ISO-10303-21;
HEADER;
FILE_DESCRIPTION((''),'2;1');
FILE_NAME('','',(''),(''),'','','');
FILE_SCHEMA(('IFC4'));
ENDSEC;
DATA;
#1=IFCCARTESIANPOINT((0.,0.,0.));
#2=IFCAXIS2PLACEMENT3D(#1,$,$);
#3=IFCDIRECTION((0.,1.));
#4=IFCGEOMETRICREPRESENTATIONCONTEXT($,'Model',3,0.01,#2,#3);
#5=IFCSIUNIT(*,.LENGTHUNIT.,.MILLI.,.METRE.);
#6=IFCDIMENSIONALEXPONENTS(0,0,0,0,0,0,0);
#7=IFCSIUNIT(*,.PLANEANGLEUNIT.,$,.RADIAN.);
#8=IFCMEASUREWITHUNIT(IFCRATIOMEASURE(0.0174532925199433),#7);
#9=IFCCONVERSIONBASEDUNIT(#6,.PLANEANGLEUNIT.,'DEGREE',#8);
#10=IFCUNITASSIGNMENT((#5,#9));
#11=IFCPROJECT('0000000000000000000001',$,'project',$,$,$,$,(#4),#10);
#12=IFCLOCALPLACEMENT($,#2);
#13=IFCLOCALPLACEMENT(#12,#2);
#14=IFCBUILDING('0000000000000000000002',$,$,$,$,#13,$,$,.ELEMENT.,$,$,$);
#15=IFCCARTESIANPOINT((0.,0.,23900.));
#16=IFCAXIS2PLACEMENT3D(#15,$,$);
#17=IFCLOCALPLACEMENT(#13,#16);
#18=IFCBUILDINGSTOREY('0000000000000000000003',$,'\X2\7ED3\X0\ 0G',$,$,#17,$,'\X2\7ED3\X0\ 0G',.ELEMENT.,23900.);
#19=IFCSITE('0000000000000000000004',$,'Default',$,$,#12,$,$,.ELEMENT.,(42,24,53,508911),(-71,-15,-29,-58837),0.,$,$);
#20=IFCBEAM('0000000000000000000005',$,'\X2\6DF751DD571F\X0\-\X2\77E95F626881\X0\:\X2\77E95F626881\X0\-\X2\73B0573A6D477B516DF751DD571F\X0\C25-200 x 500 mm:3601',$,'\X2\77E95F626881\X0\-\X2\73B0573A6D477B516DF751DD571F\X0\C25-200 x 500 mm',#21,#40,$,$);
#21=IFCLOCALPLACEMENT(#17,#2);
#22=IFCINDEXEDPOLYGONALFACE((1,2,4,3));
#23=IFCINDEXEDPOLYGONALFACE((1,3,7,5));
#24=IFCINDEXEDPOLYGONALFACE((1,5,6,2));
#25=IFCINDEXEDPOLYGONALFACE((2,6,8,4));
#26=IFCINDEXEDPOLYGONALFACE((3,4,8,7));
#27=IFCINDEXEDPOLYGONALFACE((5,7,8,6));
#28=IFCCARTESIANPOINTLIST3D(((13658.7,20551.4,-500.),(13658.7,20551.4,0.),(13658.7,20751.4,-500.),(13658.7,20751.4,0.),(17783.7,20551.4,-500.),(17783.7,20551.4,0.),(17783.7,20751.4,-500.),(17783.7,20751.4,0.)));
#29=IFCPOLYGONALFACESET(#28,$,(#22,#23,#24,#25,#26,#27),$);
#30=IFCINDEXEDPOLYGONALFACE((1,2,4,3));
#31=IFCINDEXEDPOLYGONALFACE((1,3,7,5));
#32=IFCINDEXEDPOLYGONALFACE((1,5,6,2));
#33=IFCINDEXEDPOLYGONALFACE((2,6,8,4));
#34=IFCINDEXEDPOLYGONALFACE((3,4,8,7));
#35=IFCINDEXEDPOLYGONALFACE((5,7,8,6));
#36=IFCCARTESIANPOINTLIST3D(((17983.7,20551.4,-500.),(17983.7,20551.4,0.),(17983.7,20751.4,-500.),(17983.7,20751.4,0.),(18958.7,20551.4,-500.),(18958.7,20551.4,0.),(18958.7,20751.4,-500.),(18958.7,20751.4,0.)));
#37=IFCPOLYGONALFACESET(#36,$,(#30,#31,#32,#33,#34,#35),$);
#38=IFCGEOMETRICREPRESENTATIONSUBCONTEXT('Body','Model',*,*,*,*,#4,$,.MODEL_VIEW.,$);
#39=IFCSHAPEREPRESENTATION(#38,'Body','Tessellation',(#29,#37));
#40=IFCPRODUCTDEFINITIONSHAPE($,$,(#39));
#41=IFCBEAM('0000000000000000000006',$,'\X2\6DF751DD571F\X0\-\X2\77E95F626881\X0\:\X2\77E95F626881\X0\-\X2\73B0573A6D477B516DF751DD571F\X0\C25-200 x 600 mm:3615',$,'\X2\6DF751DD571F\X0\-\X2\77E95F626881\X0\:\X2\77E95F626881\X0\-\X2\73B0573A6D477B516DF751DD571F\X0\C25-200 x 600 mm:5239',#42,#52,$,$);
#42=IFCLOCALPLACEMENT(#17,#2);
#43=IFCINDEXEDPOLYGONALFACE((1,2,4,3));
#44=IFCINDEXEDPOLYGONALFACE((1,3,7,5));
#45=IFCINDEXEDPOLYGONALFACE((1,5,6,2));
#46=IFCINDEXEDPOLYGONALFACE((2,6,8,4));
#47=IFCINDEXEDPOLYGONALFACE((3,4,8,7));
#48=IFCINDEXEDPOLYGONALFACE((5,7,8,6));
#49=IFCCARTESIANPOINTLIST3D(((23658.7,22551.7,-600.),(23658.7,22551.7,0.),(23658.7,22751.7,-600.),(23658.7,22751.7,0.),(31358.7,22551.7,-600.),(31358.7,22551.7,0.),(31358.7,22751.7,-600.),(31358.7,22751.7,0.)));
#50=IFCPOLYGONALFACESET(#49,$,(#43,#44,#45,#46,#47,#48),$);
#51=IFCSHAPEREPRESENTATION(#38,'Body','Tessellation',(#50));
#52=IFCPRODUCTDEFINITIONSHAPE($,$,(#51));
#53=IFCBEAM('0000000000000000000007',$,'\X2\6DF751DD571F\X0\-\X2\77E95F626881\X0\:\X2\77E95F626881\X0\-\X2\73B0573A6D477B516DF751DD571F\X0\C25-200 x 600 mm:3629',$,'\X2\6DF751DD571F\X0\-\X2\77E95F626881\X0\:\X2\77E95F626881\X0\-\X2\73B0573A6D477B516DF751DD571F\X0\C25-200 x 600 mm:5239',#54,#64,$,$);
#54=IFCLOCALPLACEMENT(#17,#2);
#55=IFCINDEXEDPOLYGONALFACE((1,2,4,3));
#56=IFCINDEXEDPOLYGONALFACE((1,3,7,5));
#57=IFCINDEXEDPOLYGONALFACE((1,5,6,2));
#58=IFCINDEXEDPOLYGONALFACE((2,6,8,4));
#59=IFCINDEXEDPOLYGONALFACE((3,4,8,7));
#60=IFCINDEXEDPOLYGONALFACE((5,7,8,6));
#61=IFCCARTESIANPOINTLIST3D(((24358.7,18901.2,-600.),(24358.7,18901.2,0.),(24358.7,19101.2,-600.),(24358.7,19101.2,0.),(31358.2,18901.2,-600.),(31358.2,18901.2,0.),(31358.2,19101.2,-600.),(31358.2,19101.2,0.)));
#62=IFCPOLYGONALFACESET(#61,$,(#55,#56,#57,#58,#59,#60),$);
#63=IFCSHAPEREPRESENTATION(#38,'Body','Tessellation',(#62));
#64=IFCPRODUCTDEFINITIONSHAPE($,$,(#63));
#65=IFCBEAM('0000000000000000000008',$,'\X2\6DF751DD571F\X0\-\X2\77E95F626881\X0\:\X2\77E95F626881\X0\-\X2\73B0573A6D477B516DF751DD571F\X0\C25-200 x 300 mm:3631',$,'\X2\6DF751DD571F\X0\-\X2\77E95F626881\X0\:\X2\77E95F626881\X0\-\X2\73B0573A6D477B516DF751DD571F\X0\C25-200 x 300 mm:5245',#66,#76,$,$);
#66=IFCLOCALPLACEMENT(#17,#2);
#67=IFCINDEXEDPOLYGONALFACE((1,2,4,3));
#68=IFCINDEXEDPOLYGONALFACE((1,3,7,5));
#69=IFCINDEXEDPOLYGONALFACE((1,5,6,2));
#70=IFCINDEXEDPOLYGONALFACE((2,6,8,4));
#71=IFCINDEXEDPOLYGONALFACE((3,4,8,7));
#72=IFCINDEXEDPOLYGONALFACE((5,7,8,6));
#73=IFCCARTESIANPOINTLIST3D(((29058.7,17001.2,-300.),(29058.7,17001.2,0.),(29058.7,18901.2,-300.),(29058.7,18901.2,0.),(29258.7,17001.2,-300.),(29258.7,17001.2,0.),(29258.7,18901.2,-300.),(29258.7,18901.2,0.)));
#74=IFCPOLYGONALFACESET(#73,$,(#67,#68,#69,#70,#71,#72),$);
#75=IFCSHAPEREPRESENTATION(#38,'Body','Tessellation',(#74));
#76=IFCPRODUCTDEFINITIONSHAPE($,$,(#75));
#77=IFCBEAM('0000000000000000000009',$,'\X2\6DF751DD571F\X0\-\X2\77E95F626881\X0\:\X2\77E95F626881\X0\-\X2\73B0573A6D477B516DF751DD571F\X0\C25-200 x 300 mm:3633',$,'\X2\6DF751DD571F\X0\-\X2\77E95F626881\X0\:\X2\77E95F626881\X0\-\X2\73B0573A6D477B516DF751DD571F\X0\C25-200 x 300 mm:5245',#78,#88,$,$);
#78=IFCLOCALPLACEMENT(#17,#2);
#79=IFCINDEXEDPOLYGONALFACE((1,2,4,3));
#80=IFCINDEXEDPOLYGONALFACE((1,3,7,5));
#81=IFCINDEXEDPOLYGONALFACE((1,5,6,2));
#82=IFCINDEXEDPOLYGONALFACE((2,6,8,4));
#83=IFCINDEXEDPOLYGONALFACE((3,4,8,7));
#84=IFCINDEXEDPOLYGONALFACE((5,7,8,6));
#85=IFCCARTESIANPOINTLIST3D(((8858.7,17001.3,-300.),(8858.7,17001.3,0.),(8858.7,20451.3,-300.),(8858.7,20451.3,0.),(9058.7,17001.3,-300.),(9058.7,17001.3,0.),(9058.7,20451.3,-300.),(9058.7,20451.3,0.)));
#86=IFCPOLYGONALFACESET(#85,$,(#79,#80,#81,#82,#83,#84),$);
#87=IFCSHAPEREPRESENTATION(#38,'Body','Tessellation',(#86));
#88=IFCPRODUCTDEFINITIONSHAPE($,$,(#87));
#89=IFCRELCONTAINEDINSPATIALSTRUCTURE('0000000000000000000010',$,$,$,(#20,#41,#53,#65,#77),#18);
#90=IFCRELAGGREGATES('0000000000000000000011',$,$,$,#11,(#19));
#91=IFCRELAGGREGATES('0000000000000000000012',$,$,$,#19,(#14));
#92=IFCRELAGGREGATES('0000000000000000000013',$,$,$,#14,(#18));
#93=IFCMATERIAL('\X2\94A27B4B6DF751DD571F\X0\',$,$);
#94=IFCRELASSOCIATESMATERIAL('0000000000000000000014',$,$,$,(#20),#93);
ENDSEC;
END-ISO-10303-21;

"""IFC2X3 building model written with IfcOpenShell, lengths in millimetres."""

from ifc_helpers import new_model, entity, si_unit, converted_unit, direction, frame, frame_2d, origin, origin_2d_with_axis, place, context, subcontext, project, spatial, rectangle, extrude, source, transform, mapped, material, element, save


model = new_model("IFC2X3")

# Units and contexts
model_context = context("Model", 3, precision=0.01, world=origin(), true_north=direction((0.0, 1.0)))
body_context = subcontext(model_context, "Body", "Model", "MODEL_VIEW")
ifc_project = project(units=[si_unit("LENGTHUNIT", "METRE", prefix="MILLI"), converted_unit("PLANEANGLEUNIT", "DEGREE", entity("IfcRatioMeasure", 0.0174532925199433), si_unit("PLANEANGLEUNIT", "RADIAN"), dimensions=[0, 0, 0, 0, 0, 0, 0])], contexts=[model_context])

# Site, building, storey
site_placement = place(None, origin())
site = spatial("IfcSite", under=ifc_project, at=site_placement, Name="Default", CompositionType="ELEMENT", RefLatitude=(42, 24, 53, 508911), RefLongitude=(-71, -15, -29, -58837), RefElevation=0.0)
building_placement = place(site_placement, origin())
building = spatial("IfcBuilding", under=site, at=building_placement, CompositionType="ELEMENT")
storey_placement = place(building_placement, frame((0.0, 0.0, 23900.0)))
storey = spatial("IfcBuildingStorey", under=building, at=storey_placement, Name="结 0G", LongName="结 0G", CompositionType="ELEMENT", Elevation=23900.0)

# Beams
ifc_material = material(Name="钢筋混凝土")
shared_shape = source(origin(), body_context, "Body", "SweptSolid", [
    extrude(rectangle(XDim=4125.0, YDim=200.0, at=frame_2d((0.0, 0.0), x_axis=(1.0, 0.0))), frame((15721.2, 20651.4, 23400.0)), (0.0, 0.0, 1.0), 500.0),
    extrude(rectangle(XDim=975.0, YDim=200.0, at=frame_2d((0.0, 0.0), x_axis=(1.0, 0.0))), frame((18471.2, 20651.4, 23400.0), z_axis=(0.0, 0.0, 1.0), x_axis=(-1.0, 0.0, 0.0)), (0.0, 0.0, 1.0), 500.0),
])
beam_1_placement = place(storey_placement, frame((0.0, 0.0, -23900.0)))
element("IfcBeam", 1, at=beam_1_placement, inside=storey, material=ifc_material, Name="混凝土-矩形梁:矩形梁-现场浇筑混凝土C25-200 x 500 mm:3601", ObjectType="矩形梁-现场浇筑混凝土C25-200 x 500 mm", context=body_context, shape_type="MappedRepresentation", body=[
    mapped(shared_shape, transform((0.0, 0.0, 0.0), scale=1.0)),
])
beam_2_placement = place(storey_placement, frame((31358.7, 22651.7, 0.0), z_axis=(0.0, 0.0, 1.0), x_axis=(-1.0, 0.0, 0.0)))
element("IfcBeam", 2, at=beam_2_placement, inside=storey, Name="混凝土-矩形梁:矩形梁-现场浇筑混凝土C25-200 x 600 mm:3615", ObjectType="混凝土-矩形梁:矩形梁-现场浇筑混凝土C25-200 x 600 mm:5239", context=body_context, shape_type="SweptSolid", body=[
    extrude(rectangle(XDim=600.0, YDim=200.0, at=frame_2d((0.0, 0.0), x_axis=(1.0, 0.0))), frame((0.0, 0.0, -300.0), z_axis=(1.0, 0.0, 0.0), x_axis=(0.0, 0.0, -1.0)), (0.0, 0.0, 1.0), 7700.0),
])
beam_3_placement = place(storey_placement, frame((24458.7, 19001.2, 0.0)))
element("IfcBeam", 3, at=beam_3_placement, inside=storey, Name="混凝土-矩形梁:矩形梁-现场浇筑混凝土C25-200 x 600 mm:3629", ObjectType="混凝土-矩形梁:矩形梁-现场浇筑混凝土C25-200 x 600 mm:5239", context=body_context, shape_type="SweptSolid", body=[
    extrude(rectangle(XDim=600.0, YDim=200.0, at=frame_2d((0.0, 0.0), x_axis=(1.0, 0.0))), frame((-100.0, 0.0, -300.0), z_axis=(1.0, 0.0, 0.0), x_axis=(0.0, 0.0, -1.0)), (0.0, 0.0, 1.0), 6999.5),
])
beam_4_placement = place(storey_placement, frame((29158.7, 17001.2, 0.0), z_axis=(0.0, 0.0, 1.0), x_axis=(0.0, 1.0, 0.0)))
element("IfcBeam", 4, at=beam_4_placement, inside=storey, Name="混凝土-矩形梁:矩形梁-现场浇筑混凝土C25-200 x 300 mm:3631", ObjectType="混凝土-矩形梁:矩形梁-现场浇筑混凝土C25-200 x 300 mm:5245", context=body_context, shape_type="SweptSolid", body=[
    extrude(rectangle(XDim=300.0, YDim=200.0, at=origin_2d_with_axis()), frame((0.0, 0.0, -150.0), z_axis=(1.0, 0.0, 0.0), x_axis=(0.0, 0.0, -1.0)), (0.0, 0.0, 1.0), 1900.0),
])
beam_5_placement = place(storey_placement, frame((8958.7, 17001.2, 0.0), z_axis=(0.0, 0.0, 1.0), x_axis=(0.0, 1.0, 0.0)))
element("IfcBeam", 5, at=beam_5_placement, inside=storey, Name="混凝土-矩形梁:矩形梁-现场浇筑混凝土C25-200 x 300 mm:3633", ObjectType="混凝土-矩形梁:矩形梁-现场浇筑混凝土C25-200 x 300 mm:5245", context=body_context, shape_type="SweptSolid", body=[
    extrude(rectangle(XDim=300.0, YDim=200.0, at=frame_2d((0.0, 0.0), x_axis=(1.0, 0.0))), frame((0.1, 0.0, -150.0), z_axis=(1.0, 0.0, 0.0), x_axis=(0.0, 0.0, -1.0)), (0.0, 0.0, 1.0), 3450.0),
])

save(model, "model.ifc")
